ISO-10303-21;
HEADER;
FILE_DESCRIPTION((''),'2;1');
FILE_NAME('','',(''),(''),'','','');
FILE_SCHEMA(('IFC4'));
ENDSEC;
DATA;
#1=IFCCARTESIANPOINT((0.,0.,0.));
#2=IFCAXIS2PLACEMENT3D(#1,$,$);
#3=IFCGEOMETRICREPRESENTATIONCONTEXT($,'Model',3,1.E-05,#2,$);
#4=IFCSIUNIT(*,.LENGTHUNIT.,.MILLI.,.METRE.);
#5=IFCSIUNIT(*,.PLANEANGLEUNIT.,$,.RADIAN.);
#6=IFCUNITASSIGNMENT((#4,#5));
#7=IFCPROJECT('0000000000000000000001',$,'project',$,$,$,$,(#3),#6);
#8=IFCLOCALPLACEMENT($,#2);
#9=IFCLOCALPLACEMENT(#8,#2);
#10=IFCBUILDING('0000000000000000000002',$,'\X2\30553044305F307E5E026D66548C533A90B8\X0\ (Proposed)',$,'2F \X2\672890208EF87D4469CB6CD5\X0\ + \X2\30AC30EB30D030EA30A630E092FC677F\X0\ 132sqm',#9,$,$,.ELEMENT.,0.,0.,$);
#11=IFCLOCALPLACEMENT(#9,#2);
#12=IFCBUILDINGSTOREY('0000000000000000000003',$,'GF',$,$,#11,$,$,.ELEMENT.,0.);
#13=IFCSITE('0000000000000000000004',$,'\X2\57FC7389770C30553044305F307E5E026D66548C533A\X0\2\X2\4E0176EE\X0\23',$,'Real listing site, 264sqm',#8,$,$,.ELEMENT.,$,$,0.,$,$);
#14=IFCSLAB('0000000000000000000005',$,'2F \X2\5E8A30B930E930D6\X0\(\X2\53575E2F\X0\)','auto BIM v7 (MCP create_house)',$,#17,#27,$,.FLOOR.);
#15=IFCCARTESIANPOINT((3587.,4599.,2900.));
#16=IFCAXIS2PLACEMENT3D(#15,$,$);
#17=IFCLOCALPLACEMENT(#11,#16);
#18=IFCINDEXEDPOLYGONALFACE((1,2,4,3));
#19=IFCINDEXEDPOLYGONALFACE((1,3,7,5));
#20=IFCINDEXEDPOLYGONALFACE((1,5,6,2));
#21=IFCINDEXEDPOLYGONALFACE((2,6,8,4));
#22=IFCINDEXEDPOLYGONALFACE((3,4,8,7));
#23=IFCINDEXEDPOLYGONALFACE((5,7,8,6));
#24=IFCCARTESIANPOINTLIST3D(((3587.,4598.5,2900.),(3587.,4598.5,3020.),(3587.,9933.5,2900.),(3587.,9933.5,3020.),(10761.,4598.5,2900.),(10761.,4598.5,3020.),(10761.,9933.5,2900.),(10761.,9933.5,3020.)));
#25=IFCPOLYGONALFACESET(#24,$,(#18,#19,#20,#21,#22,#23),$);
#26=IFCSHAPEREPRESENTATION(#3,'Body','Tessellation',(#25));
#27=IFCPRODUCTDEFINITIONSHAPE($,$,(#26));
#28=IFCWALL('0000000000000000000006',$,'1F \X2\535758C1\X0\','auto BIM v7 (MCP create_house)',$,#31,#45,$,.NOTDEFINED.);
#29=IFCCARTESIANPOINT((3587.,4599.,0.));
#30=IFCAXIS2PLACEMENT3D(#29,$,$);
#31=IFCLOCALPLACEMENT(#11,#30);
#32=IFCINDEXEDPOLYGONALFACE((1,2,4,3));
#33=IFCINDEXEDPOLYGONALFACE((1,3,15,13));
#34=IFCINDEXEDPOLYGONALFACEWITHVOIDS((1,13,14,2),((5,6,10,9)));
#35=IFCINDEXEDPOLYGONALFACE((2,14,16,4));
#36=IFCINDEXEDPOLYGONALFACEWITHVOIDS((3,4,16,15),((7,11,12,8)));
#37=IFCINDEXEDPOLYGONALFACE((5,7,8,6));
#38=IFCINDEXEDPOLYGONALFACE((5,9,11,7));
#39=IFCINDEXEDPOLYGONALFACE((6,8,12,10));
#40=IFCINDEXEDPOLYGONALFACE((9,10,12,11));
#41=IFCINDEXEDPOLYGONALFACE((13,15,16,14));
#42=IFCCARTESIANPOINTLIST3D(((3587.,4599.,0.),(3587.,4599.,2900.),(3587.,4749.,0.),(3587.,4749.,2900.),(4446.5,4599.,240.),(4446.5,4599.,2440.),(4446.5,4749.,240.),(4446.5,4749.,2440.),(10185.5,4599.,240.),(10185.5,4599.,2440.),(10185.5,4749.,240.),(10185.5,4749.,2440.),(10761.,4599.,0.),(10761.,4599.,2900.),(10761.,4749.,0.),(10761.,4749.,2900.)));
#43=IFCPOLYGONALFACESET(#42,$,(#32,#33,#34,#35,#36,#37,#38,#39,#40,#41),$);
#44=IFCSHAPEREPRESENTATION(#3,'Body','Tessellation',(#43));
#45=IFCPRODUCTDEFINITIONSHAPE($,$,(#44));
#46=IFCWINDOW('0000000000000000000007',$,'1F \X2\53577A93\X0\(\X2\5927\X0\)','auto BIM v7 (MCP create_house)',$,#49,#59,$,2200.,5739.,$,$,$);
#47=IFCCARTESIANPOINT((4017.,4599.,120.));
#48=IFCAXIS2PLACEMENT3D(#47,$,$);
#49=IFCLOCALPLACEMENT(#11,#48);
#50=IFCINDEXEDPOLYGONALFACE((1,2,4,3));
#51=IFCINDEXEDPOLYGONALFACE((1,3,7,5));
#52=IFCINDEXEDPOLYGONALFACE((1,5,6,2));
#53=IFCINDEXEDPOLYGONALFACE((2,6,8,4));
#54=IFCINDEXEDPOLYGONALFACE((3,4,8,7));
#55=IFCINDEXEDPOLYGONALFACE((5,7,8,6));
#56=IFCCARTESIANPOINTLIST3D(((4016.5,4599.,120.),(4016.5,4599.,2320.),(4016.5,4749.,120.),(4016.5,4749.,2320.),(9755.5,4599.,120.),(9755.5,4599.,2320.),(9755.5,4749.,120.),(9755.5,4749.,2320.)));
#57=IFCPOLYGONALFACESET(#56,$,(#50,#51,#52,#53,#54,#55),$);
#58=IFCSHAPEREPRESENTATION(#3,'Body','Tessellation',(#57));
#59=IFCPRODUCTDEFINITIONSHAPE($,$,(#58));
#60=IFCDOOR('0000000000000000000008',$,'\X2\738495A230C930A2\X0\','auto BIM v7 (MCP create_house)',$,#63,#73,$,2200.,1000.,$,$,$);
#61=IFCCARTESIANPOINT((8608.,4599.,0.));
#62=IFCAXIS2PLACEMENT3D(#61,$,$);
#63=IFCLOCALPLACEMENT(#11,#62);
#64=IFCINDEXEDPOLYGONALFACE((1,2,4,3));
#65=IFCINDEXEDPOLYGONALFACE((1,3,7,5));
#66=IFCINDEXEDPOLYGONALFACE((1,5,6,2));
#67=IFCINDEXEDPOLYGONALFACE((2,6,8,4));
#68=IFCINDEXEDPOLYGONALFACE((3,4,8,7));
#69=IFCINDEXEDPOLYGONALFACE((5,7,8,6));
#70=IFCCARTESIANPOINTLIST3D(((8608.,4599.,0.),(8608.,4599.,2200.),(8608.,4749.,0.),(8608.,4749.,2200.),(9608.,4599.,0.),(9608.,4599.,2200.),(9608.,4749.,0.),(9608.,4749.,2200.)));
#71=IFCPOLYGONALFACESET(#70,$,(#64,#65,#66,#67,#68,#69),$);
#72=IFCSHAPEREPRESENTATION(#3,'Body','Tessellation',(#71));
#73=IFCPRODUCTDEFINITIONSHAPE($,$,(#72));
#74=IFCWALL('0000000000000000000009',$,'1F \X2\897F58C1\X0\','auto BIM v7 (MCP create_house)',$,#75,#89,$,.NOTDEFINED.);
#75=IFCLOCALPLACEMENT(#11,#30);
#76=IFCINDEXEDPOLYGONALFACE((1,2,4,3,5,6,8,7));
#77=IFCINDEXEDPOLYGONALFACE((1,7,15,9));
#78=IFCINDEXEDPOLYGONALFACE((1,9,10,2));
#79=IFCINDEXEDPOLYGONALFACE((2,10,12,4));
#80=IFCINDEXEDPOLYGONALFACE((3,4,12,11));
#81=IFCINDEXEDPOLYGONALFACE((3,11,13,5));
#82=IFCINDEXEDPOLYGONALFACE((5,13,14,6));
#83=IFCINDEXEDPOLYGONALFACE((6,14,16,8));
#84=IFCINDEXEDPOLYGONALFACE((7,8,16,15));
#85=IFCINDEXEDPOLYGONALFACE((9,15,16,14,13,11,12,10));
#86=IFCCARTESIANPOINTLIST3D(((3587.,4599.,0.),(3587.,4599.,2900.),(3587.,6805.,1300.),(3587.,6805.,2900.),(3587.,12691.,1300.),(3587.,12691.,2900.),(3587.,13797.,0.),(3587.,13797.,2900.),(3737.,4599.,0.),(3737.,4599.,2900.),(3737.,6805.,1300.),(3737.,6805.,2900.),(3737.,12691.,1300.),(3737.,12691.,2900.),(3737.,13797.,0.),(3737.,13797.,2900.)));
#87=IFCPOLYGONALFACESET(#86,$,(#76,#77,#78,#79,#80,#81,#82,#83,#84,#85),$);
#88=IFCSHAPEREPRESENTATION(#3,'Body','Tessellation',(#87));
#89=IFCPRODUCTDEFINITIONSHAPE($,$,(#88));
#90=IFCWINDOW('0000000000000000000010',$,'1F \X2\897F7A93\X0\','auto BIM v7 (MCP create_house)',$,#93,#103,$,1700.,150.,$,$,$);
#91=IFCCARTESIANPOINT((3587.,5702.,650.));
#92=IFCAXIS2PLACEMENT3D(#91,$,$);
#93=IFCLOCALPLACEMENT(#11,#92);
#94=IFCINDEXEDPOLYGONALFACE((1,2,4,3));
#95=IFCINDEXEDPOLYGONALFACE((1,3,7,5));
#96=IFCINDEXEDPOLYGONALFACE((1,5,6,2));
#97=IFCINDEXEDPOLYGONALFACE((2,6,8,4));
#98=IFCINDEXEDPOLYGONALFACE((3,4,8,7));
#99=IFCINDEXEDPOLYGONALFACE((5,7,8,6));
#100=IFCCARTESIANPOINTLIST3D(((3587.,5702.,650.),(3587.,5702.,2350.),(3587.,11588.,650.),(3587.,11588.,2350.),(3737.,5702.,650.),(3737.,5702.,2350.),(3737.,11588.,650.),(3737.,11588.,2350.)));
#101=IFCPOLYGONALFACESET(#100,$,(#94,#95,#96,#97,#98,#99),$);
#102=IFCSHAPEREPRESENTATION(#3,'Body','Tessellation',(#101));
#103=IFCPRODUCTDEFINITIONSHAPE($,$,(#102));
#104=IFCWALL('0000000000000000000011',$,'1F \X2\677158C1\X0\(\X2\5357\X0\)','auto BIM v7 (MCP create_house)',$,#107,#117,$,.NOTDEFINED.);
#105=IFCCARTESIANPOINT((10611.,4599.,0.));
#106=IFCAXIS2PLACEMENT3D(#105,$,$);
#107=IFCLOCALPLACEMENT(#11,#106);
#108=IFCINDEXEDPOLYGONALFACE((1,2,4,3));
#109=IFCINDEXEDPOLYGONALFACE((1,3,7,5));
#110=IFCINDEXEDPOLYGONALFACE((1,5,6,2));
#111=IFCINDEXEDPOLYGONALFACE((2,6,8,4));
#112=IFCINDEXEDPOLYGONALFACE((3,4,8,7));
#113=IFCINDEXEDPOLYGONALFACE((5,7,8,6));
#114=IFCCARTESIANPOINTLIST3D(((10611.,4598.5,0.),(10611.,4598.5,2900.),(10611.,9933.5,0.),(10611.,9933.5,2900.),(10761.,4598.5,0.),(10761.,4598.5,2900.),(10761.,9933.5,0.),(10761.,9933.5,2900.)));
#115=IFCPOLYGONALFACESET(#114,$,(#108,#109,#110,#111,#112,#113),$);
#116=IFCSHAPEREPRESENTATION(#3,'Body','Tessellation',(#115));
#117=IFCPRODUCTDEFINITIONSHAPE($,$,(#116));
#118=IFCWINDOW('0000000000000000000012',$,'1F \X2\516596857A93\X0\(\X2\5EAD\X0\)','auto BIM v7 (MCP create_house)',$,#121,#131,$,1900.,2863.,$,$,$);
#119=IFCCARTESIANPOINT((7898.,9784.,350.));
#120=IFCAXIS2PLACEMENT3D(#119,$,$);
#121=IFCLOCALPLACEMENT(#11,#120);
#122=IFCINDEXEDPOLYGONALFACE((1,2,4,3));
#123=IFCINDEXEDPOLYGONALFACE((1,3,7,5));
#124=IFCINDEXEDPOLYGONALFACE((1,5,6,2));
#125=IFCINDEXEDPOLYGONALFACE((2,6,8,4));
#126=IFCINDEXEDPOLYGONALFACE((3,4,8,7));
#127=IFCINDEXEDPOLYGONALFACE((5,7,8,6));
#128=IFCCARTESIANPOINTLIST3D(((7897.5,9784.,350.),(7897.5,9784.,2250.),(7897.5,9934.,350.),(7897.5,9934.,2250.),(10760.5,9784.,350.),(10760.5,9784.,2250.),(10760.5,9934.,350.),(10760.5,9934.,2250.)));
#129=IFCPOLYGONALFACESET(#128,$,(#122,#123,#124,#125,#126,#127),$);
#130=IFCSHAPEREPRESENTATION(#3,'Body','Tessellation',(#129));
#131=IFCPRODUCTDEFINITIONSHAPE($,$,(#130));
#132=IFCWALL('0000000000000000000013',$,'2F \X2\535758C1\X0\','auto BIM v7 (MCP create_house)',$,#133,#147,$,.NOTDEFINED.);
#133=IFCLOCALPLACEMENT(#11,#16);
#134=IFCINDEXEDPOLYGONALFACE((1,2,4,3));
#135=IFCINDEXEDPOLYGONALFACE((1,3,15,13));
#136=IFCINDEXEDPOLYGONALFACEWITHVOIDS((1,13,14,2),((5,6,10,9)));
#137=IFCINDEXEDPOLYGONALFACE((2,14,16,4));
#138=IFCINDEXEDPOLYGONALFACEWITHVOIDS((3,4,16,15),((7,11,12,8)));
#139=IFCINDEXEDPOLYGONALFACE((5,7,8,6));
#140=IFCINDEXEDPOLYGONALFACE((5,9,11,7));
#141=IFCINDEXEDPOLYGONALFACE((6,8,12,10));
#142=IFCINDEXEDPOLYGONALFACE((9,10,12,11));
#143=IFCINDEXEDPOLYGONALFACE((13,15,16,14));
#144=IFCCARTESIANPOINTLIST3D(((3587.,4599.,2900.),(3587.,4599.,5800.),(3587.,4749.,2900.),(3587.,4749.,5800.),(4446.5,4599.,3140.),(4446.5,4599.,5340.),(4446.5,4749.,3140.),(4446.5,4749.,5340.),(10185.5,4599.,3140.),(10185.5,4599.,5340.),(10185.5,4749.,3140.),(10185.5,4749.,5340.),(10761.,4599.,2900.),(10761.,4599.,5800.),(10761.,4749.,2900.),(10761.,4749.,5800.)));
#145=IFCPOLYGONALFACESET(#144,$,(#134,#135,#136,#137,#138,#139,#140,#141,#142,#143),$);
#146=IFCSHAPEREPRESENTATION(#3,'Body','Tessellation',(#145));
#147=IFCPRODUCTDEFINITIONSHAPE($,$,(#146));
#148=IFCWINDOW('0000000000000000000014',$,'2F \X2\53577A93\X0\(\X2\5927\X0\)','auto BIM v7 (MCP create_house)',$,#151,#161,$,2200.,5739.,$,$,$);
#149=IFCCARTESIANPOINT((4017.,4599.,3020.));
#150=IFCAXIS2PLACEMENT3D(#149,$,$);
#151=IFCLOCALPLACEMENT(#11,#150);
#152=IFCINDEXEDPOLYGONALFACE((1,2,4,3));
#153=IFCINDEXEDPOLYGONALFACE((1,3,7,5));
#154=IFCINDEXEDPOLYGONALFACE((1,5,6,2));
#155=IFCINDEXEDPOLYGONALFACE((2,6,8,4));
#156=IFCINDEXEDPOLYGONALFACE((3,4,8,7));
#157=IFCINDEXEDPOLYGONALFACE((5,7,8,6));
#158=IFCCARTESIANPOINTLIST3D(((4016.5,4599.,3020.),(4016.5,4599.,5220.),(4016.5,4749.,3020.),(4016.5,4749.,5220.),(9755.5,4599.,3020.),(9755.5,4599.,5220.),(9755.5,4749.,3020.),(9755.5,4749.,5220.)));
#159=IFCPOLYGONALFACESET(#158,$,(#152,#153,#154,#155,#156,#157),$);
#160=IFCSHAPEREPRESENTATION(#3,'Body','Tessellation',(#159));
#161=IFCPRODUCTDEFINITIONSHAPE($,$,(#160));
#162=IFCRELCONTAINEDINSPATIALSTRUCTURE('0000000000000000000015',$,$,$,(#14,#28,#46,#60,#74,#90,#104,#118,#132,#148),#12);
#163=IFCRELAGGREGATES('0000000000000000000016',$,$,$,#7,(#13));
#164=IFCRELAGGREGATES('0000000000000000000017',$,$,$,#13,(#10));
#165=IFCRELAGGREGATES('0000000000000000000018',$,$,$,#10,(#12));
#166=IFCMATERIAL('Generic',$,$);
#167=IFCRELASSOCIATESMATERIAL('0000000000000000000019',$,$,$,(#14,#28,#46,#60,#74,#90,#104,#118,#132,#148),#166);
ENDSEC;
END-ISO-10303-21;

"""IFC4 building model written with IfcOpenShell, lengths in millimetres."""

from ifc_helpers import new_model, si_unit, frame, frame_2d, origin, place, context, project, spatial, rectangle, extrude, material, element, fill, save


model = new_model("IFC4")

# Units and contexts
model_context = context("Model", 3, precision=1e-05, world=origin())
ifc_project = project(units=[si_unit("LENGTHUNIT", "METRE", prefix="MILLI"), si_unit("PLANEANGLEUNIT", "RADIAN")], contexts=[model_context])

# Site, building, storey
site_placement = place(None, origin())
site = spatial("IfcSite", under=ifc_project, at=site_placement, Name="埼玉県さいたま市浦和区2丁目23", ObjectType="Real listing site, 264sqm", CompositionType="ELEMENT", RefElevation=0.0)
building_placement = place(site_placement, origin())
building = spatial("IfcBuilding", under=site, at=building_placement, Name="さいたま市浦和区邸 (Proposed)", ObjectType="2F 木造軸組構法 + ガルバリウム鋼板 132sqm", CompositionType="ELEMENT", ElevationOfRefHeight=0.0, ElevationOfTerrain=0.0)
storey_placement = place(building_placement, origin())
storey = spatial("IfcBuildingStorey", under=building, at=storey_placement, Name="GF", CompositionType="ELEMENT", Elevation=0.0)

# Slab
ifc_material = material(Name="Generic")
slab_1_placement = place(storey_placement, frame((3587.0, 4599.0, 2900.0)))
element("IfcSlab", 1, at=slab_1_placement, inside=storey, material=ifc_material, Name="2F 床スラブ(南帯)", Description="auto BIM v7 (MCP create_house)", PredefinedType="FLOOR", context=model_context, shape_type="SweptSolid", body=[
    extrude(rectangle(XDim=7174.0, YDim=5335.0, at=frame_2d((3587.0, 2667.0))), frame((3587.0, 4599.0, 2900.0)), (0.0, 0.0, 1.0), 120.0),
])

# Wall, openings, window, door
wall_1_placement = place(storey_placement, frame((3587.0, 4599.0, 0.0)))
wall_1 = element("IfcWall", 2, at=wall_1_placement, inside=storey, material=ifc_material, Name="1F 南壁", Description="auto BIM v7 (MCP create_house)", PredefinedType="NOTDEFINED", context=model_context, shape_type="SweptSolid", body=[
    extrude(rectangle(XDim=7174.0, YDim=150.0, at=frame_2d((3587.0, 75.0))), frame((3587.0, 4599.0, 0.0)), (0.0, 0.0, 1.0), 2900.0),
])
opening_1_placement = place(storey_placement, frame((4017.0, 4599.0, 120.0)))
opening_1 = element("IfcOpeningElement", 3, at=opening_1_placement, cuts=wall_1, PredefinedType="NOTDEFINED", context=model_context, shape_type="SweptSolid", body=[
    extrude(rectangle(XDim=5739.0, YDim=150.0, at=frame_2d((2869.0, 75.0))), frame((4017.0, 4599.0, 120.0)), (0.0, 0.0, 1.0), 2200.0),
])
opening_2_placement = place(storey_placement, frame((8608.0, 4599.0, 0.0)))
opening_2 = element("IfcOpeningElement", 4, at=opening_2_placement, cuts=wall_1, PredefinedType="NOTDEFINED", context=model_context, shape_type="SweptSolid", body=[
    extrude(rectangle(XDim=1000.0, YDim=150.0, at=frame_2d((500.0, 75.0))), frame((8608.0, 4599.0, 0.0)), (0.0, 0.0, 1.0), 2200.0),
])
window_1_placement = place(storey_placement, frame((4017.0, 4599.0, 120.0)))
window_1 = element("IfcWindow", 5, at=window_1_placement, inside=storey, material=ifc_material, Name="1F 南窓(大)", Description="auto BIM v7 (MCP create_house)", OverallHeight=2200.0, OverallWidth=5739.0, context=model_context, shape_type="SweptSolid", body=[
    extrude(rectangle(XDim=5739.0, YDim=150.0, at=frame_2d((2869.0, 75.0))), frame((4017.0, 4599.0, 120.0)), (0.0, 0.0, 1.0), 2200.0),
])
fill(opening_1, window_1)
door_placement = place(storey_placement, frame((8608.0, 4599.0, 0.0)))
door = element("IfcDoor", 6, at=door_placement, inside=storey, material=ifc_material, Name="玄関ドア", Description="auto BIM v7 (MCP create_house)", OverallHeight=2200.0, OverallWidth=1000.0, context=model_context, shape_type="SweptSolid", body=[
    extrude(rectangle(XDim=1000.0, YDim=150.0, at=frame_2d((500.0, 75.0))), frame((8608.0, 4599.0, 0.0)), (0.0, 0.0, 1.0), 2200.0),
])
fill(opening_2, door)

# Walls, openings, windows
wall_2_placement = place(storey_placement, frame((3587.0, 4599.0, 0.0)))
wall_2 = element("IfcWall", 7, at=wall_2_placement, inside=storey, material=ifc_material, Name="1F 西壁", Description="auto BIM v7 (MCP create_house)", PredefinedType="NOTDEFINED", context=model_context, shape_type="SweptSolid", body=[
    extrude(rectangle(XDim=150.0, YDim=9198.0, at=frame_2d((75.0, 4599.0))), frame((3587.0, 4599.0, 0.0)), (0.0, 0.0, 1.0), 2900.0),
])
opening_3_placement = place(storey_placement, frame((3587.0, 5702.0, 650.0)))
opening_3 = element("IfcOpeningElement", 8, at=opening_3_placement, cuts=wall_2, PredefinedType="NOTDEFINED", context=model_context, shape_type="SweptSolid", body=[
    extrude(rectangle(XDim=150.0, YDim=5886.0, at=frame_2d((75.0, 2943.0))), frame((3587.0, 5702.0, 650.0)), (0.0, 0.0, 1.0), 1700.0),
])
window_2_placement = place(storey_placement, frame((3587.0, 5702.0, 650.0)))
window_2 = element("IfcWindow", 9, at=window_2_placement, inside=storey, material=ifc_material, Name="1F 西窓", Description="auto BIM v7 (MCP create_house)", OverallHeight=1700.0, OverallWidth=150.0, context=model_context, shape_type="SweptSolid", body=[
    extrude(rectangle(XDim=150.0, YDim=5886.0, at=frame_2d((75.0, 2943.0))), frame((3587.0, 5702.0, 650.0)), (0.0, 0.0, 1.0), 1700.0),
])
fill(opening_3, window_2)
wall_3_placement = place(storey_placement, frame((10611.0, 4599.0, 0.0)))
wall_3 = element("IfcWall", 10, at=wall_3_placement, inside=storey, material=ifc_material, Name="1F 東壁(南)", Description="auto BIM v7 (MCP create_house)", PredefinedType="NOTDEFINED", context=model_context, shape_type="SweptSolid", body=[
    extrude(rectangle(XDim=150.0, YDim=5335.0, at=frame_2d((75.0, 2667.0))), frame((10611.0, 4599.0, 0.0)), (0.0, 0.0, 1.0), 2900.0),
])
opening_4_placement = place(storey_placement, frame((7898.0, 9784.0, 350.0)))
opening_4 = element("IfcOpeningElement", 11, at=opening_4_placement, cuts=wall_3, PredefinedType="NOTDEFINED", context=model_context, shape_type="SweptSolid", body=[
    extrude(rectangle(XDim=2863.0, YDim=150.0, at=frame_2d((1431.0, 75.0))), frame((7898.0, 9784.0, 350.0)), (0.0, 0.0, 1.0), 1900.0),
])
window_3_placement = place(storey_placement, frame((7898.0, 9784.0, 350.0)))
window_3 = element("IfcWindow", 12, at=window_3_placement, inside=storey, material=ifc_material, Name="1F 入隅窓(庭)", Description="auto BIM v7 (MCP create_house)", OverallHeight=1900.0, OverallWidth=2863.0, context=model_context, shape_type="SweptSolid", body=[
    extrude(rectangle(XDim=2863.0, YDim=150.0, at=frame_2d((1431.0, 75.0))), frame((7898.0, 9784.0, 350.0)), (0.0, 0.0, 1.0), 1900.0),
])
fill(opening_4, window_3)

# Wall, opening, window
wall_4_placement = place(storey_placement, frame((3587.0, 4599.0, 2900.0)))
wall_4 = element("IfcWall", 13, at=wall_4_placement, inside=storey, material=ifc_material, Name="2F 南壁", Description="auto BIM v7 (MCP create_house)", PredefinedType="NOTDEFINED", context=model_context, shape_type="SweptSolid", body=[
    extrude(rectangle(XDim=7174.0, YDim=150.0, at=frame_2d((3587.0, 75.0))), frame((3587.0, 4599.0, 2900.0)), (0.0, 0.0, 1.0), 2900.0),
])
opening_5_placement = place(storey_placement, frame((4017.0, 4599.0, 3020.0)))
opening_5 = element("IfcOpeningElement", 14, at=opening_5_placement, cuts=wall_4, PredefinedType="NOTDEFINED", context=model_context, shape_type="SweptSolid", body=[
    extrude(rectangle(XDim=5739.0, YDim=150.0, at=frame_2d((2869.0, 75.0))), frame((4017.0, 4599.0, 3020.0)), (0.0, 0.0, 1.0), 2200.0),
])
window_4_placement = place(storey_placement, frame((4017.0, 4599.0, 3020.0)))
window_4 = element("IfcWindow", 15, at=window_4_placement, inside=storey, material=ifc_material, Name="2F 南窓(大)", Description="auto BIM v7 (MCP create_house)", OverallHeight=2200.0, OverallWidth=5739.0, context=model_context, shape_type="SweptSolid", body=[
    extrude(rectangle(XDim=5739.0, YDim=150.0, at=frame_2d((2869.0, 75.0))), frame((4017.0, 4599.0, 3020.0)), (0.0, 0.0, 1.0), 2200.0),
])
fill(opening_5, window_4)

save(model, "model.ifc")
